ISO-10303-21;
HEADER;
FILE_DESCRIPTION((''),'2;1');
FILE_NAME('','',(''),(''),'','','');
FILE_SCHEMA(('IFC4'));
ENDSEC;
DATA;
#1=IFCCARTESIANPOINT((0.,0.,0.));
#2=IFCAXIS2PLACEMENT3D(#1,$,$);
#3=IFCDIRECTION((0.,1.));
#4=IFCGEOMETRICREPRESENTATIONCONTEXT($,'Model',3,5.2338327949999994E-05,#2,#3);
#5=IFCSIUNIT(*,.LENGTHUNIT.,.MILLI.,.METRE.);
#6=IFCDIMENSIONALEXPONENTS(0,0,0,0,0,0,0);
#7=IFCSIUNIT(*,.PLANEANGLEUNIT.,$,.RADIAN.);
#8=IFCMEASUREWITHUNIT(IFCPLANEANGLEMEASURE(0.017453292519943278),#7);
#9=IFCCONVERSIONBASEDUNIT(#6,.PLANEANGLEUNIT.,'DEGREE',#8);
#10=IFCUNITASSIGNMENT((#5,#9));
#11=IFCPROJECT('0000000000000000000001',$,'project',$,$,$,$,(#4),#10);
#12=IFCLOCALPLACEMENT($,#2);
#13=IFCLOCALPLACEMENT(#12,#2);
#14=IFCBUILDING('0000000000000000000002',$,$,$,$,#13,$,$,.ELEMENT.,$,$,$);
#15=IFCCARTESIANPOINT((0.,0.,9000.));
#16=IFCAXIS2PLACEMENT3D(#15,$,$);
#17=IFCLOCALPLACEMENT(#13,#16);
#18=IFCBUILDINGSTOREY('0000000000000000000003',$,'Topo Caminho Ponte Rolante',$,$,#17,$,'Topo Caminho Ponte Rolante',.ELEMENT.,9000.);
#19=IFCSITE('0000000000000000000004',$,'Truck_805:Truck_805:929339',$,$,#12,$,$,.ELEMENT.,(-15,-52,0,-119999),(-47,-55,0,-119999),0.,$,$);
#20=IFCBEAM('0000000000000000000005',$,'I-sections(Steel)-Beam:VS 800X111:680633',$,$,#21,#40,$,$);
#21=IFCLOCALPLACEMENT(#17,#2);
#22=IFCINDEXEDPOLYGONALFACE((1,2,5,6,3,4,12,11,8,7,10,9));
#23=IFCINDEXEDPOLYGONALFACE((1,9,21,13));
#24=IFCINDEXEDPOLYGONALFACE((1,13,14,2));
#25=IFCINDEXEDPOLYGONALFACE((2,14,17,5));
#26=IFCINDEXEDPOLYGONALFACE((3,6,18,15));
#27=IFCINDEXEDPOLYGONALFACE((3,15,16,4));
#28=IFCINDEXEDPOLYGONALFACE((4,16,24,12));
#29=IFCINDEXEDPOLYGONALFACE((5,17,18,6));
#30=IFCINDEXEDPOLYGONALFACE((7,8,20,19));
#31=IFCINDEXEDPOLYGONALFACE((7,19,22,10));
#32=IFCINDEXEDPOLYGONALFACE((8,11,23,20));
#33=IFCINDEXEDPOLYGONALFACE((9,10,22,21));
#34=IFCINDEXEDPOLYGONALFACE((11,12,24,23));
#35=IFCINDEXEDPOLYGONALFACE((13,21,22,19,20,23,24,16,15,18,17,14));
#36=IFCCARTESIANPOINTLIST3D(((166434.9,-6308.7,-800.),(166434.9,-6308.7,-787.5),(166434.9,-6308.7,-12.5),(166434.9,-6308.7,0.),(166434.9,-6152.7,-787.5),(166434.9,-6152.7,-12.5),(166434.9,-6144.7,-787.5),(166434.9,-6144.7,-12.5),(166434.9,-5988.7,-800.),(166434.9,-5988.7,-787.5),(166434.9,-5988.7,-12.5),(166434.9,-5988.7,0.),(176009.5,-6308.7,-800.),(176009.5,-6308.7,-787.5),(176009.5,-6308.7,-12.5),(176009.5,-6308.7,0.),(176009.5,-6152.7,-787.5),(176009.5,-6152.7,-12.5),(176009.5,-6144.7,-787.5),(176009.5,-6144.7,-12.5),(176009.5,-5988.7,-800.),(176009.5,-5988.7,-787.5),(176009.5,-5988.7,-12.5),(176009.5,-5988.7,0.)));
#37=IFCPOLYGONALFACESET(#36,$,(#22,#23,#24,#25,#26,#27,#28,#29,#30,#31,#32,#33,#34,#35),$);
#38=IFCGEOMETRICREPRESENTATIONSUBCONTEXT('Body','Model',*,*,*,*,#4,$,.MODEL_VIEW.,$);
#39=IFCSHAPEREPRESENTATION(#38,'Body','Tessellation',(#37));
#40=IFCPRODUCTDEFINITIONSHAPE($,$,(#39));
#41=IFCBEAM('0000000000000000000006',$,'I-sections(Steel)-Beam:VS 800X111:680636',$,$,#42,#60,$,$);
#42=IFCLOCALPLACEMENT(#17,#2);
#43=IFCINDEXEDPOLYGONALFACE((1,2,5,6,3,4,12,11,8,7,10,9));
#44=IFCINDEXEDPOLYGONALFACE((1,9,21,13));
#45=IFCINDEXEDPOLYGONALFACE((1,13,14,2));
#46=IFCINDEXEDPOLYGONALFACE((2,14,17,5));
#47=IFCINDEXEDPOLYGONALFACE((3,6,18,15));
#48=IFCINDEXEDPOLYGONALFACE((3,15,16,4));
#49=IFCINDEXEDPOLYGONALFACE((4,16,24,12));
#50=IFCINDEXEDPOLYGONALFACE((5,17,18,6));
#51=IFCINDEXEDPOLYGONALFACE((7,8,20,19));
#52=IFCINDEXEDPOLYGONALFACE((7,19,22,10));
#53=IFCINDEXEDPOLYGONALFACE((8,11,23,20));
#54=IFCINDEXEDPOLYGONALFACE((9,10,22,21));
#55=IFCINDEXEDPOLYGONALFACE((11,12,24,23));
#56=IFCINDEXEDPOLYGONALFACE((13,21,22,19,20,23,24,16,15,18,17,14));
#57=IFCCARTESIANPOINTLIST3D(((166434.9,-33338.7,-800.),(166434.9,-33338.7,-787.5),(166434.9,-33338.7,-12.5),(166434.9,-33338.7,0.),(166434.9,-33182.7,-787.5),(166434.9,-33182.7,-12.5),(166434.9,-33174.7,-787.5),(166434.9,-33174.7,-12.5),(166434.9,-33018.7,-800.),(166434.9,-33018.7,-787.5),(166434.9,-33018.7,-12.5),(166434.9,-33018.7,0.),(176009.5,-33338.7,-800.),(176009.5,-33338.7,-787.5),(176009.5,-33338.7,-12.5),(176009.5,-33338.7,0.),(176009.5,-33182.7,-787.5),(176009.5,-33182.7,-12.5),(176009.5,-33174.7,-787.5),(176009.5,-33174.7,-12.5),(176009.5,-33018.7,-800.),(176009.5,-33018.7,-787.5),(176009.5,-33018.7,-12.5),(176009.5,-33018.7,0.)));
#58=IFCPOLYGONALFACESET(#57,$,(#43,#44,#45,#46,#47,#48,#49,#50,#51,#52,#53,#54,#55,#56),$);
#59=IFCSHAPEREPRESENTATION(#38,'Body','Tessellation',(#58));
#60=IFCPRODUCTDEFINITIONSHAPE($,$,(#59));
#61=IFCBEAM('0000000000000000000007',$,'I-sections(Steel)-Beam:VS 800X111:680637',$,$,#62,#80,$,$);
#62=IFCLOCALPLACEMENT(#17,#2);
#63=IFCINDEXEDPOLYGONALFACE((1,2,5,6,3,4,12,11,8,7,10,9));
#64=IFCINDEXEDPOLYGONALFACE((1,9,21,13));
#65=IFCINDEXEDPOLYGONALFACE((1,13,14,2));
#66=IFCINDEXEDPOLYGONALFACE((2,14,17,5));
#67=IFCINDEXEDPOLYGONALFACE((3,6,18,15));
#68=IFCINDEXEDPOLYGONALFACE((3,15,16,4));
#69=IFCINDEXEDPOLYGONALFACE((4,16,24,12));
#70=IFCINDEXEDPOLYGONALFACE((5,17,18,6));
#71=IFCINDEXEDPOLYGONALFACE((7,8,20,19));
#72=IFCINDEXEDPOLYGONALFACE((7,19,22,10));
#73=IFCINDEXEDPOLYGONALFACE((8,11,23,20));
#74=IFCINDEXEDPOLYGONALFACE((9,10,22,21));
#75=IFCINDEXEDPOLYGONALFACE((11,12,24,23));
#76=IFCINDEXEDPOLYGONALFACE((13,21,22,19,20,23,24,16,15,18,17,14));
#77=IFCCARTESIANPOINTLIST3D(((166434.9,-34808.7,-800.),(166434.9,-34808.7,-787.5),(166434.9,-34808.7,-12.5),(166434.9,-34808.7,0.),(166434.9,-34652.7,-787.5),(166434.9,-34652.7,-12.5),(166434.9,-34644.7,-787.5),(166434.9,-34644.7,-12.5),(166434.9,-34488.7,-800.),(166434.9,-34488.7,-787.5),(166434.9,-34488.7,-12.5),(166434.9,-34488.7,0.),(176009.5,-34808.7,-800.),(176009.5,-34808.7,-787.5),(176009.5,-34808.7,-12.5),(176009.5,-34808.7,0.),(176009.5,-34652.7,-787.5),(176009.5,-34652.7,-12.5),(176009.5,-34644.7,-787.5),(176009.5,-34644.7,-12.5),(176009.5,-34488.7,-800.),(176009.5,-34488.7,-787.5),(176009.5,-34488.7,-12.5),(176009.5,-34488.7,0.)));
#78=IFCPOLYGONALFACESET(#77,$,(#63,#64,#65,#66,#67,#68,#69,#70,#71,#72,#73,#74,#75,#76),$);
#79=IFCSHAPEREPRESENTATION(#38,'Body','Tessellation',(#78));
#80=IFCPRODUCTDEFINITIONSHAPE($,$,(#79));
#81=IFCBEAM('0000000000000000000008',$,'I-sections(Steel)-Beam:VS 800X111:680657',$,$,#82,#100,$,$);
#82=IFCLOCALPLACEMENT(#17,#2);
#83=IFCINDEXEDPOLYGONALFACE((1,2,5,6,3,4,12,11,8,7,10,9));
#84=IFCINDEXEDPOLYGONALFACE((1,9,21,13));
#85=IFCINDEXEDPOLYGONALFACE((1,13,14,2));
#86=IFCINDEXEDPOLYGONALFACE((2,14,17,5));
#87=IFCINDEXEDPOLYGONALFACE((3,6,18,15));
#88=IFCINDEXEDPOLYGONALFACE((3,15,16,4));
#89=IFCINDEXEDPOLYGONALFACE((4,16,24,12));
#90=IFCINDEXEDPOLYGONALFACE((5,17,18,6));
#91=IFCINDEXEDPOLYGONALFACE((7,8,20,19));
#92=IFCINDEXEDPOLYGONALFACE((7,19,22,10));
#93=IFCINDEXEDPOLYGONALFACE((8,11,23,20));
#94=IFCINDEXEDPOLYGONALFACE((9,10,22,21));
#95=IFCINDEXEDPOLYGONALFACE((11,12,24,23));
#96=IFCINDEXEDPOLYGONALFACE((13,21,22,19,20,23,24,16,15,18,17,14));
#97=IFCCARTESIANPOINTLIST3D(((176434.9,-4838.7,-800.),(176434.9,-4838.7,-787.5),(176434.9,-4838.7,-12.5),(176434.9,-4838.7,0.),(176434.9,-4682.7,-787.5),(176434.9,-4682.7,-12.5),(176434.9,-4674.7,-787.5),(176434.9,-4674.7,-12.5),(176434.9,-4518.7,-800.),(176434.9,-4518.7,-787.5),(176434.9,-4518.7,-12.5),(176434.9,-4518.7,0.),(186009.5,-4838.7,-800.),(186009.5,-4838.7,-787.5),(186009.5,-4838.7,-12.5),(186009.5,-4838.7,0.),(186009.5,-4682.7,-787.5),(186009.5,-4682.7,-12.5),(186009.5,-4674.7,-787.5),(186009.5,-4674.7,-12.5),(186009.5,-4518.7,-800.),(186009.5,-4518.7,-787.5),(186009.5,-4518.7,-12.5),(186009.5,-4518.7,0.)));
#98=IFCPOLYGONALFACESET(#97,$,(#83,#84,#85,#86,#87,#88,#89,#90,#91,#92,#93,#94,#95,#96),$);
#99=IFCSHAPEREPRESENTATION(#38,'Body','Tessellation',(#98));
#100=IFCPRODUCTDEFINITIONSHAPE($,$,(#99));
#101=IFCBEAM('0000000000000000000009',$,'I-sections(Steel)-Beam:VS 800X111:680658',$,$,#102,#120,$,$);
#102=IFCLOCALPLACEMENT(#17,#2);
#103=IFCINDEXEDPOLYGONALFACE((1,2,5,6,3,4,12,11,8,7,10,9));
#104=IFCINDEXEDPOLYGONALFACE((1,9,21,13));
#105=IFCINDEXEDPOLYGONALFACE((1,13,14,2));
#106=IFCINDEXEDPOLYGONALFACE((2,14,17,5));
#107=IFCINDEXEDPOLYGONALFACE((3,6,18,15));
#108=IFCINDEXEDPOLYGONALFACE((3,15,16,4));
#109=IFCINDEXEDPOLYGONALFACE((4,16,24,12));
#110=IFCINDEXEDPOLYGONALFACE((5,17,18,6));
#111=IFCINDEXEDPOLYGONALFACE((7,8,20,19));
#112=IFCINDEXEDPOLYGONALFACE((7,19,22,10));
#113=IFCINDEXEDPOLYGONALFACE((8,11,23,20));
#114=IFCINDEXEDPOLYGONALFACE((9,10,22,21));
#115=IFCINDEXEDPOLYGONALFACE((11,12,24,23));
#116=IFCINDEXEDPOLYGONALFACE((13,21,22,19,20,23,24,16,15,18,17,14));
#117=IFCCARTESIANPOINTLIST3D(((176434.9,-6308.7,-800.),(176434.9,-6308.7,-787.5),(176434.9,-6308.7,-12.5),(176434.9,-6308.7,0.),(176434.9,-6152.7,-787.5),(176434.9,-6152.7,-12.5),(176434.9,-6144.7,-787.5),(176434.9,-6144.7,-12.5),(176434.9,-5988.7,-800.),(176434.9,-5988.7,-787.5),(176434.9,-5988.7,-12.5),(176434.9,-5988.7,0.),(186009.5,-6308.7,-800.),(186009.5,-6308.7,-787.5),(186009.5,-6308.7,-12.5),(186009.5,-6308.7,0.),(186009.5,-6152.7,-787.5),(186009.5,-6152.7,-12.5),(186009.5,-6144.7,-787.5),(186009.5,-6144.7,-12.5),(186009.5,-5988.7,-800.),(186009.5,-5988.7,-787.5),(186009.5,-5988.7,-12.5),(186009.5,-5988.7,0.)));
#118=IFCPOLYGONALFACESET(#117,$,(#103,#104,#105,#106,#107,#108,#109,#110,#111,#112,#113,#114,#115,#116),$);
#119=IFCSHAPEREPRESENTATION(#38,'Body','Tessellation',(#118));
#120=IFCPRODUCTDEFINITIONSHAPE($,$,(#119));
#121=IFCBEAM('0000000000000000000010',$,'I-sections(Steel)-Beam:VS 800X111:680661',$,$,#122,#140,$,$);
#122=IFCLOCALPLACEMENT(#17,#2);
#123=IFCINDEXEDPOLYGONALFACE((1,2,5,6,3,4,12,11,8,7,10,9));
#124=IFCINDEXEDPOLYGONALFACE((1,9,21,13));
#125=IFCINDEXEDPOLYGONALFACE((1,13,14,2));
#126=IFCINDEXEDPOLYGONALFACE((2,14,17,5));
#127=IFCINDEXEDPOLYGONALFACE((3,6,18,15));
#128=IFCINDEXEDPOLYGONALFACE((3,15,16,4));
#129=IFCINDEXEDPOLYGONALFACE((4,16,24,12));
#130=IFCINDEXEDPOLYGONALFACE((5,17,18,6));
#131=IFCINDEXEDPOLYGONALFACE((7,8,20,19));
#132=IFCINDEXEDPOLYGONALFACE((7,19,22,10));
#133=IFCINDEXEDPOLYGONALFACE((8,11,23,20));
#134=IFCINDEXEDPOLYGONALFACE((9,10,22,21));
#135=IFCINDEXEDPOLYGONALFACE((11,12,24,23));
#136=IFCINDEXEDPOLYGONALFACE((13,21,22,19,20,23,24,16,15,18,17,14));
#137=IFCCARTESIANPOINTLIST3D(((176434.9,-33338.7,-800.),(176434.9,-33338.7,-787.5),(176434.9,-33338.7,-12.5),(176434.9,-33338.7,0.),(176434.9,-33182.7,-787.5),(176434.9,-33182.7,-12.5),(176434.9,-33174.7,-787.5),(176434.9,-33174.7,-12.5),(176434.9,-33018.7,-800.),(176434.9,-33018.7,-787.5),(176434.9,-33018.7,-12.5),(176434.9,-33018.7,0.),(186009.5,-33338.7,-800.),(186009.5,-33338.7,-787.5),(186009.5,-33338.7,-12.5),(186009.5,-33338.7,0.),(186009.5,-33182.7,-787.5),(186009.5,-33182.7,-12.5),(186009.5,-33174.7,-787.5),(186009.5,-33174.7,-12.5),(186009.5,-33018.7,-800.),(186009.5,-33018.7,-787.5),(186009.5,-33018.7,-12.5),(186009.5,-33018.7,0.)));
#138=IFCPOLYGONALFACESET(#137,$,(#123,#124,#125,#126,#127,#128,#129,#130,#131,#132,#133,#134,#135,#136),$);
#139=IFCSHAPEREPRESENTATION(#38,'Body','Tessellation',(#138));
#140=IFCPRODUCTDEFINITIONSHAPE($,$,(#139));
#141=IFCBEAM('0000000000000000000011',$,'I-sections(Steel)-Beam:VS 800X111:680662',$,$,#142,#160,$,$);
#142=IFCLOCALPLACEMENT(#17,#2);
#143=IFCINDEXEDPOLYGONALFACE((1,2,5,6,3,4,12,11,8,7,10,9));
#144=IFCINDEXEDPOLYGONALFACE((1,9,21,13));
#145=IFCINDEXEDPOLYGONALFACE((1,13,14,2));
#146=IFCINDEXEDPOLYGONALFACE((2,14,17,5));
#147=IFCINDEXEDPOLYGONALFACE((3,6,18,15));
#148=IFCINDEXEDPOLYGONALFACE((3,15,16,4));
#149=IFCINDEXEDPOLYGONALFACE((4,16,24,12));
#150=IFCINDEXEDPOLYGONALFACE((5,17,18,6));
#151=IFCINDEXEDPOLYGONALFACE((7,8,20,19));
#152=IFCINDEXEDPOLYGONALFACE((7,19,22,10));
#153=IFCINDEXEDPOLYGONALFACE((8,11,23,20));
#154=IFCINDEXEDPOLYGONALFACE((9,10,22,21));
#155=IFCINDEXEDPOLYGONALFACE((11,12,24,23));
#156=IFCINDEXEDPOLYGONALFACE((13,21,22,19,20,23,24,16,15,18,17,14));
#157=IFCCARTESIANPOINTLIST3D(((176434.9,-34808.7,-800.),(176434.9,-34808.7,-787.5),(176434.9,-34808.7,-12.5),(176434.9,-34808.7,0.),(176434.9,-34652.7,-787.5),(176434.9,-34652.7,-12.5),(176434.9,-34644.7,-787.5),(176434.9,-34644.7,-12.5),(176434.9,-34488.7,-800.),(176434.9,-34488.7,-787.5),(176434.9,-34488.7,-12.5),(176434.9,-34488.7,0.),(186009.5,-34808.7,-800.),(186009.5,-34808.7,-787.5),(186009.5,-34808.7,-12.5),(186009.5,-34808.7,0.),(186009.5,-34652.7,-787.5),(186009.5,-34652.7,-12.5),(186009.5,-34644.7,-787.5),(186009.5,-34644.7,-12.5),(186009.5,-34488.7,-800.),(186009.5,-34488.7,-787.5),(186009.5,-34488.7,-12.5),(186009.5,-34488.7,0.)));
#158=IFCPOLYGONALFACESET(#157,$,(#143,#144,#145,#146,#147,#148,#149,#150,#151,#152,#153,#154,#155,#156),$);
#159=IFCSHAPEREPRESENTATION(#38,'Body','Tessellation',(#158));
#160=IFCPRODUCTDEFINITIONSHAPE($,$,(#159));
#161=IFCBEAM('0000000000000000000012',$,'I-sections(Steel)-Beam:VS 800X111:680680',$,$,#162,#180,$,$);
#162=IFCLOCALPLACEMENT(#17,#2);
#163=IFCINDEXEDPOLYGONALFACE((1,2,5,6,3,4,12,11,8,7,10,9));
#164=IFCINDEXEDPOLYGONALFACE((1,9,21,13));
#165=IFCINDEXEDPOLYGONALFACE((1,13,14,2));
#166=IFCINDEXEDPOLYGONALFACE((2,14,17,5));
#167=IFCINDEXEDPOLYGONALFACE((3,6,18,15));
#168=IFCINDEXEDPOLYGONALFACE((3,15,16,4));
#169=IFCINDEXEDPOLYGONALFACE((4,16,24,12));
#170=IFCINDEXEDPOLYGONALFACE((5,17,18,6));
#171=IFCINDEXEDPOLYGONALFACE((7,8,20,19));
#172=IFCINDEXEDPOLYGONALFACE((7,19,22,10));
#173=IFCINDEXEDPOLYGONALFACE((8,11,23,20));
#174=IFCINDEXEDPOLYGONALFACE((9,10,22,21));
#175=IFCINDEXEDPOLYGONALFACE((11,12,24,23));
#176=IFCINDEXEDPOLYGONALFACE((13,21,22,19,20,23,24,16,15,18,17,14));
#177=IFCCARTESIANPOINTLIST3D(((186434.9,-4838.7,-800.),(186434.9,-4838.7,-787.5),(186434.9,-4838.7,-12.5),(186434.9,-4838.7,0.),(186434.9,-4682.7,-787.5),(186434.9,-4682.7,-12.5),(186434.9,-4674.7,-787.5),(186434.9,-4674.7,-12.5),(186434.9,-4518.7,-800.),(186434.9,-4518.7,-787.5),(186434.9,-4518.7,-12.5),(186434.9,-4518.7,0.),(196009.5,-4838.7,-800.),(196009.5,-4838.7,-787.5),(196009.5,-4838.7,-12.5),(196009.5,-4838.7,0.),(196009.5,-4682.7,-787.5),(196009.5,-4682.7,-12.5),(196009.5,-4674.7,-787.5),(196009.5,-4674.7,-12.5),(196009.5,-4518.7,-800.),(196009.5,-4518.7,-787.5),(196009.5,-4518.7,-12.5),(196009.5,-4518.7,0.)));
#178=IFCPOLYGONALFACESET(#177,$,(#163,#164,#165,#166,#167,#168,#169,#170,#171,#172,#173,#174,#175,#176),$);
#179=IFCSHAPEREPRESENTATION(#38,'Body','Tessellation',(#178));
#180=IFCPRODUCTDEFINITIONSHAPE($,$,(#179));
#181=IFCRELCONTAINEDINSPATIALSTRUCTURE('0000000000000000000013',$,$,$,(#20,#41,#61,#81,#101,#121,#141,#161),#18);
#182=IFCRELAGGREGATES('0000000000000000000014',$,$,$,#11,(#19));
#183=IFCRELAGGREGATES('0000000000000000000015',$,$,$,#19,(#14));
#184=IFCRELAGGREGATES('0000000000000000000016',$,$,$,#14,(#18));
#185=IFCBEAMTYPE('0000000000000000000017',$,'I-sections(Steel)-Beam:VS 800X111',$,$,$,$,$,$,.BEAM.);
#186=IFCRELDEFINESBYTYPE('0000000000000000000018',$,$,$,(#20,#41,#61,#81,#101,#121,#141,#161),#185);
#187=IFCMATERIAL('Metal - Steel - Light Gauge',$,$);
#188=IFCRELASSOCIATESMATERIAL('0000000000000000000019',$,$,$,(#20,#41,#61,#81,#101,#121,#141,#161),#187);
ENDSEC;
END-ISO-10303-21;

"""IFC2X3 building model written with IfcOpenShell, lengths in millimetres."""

from ifc_helpers import new_model, entity, si_unit, converted_unit, direction, frame, frame_2d, origin, place, context, subcontext, project, spatial, polyline, i_section, outline, extrude, material, type_object, element, save


model = new_model("IFC2X3")

# Units and contexts
model_context = context("Model", 3, precision=5.2338327949999994e-05, world=origin(), true_north=direction((0.0, 1.0)))
body_context = subcontext(model_context, "Body", "Model", "MODEL_VIEW")
ifc_project = project(units=[si_unit("LENGTHUNIT", "METRE", prefix="MILLI"), converted_unit("PLANEANGLEUNIT", "DEGREE", entity("IfcPlaneAngleMeasure", 0.017453292519943278), si_unit("PLANEANGLEUNIT", "RADIAN"), dimensions=[0, 0, 0, 0, 0, 0, 0])], contexts=[model_context])

# Site, building, storey
site_placement = place(None, origin())
site = spatial("IfcSite", under=ifc_project, at=site_placement, Name="Truck_805:Truck_805:929339", CompositionType="ELEMENT", RefLatitude=(-15, -52, 0, -119999), RefLongitude=(-47, -55, 0, -119999), RefElevation=0.0)
building_placement = place(site_placement, origin())
building = spatial("IfcBuilding", under=site, at=building_placement, CompositionType="ELEMENT")
storey_placement = place(building_placement, frame((0.0, 0.0, 9000.0)))
storey = spatial("IfcBuildingStorey", under=building, at=storey_placement, Name="Topo Caminho Ponte Rolante", LongName="Topo Caminho Ponte Rolante", CompositionType="ELEMENT", Elevation=9000.0)

# Beams
ifc_material = material(Name="Metal - Steel - Light Gauge")
beam_type_1 = type_object("IfcBeamType", Name="I-sections(Steel)-Beam:VS 800X111", PredefinedType="BEAM")
beam_1_placement = place(storey_placement, frame((166222.2, -6148.7, 0.0)))
element("IfcBeam", 1, at=beam_1_placement, inside=storey, type_object=beam_type_1, material=ifc_material, Name="I-sections(Steel)-Beam:VS 800X111:680633", context=body_context, shape_type="SweptSolid", body=[
    extrude(outline(polyline([(387.5, -160.0), (400.0, -160.0), (400.0, 160.0), (387.5, 160.0), (387.5, 4.0), (-387.5, 4.0), (-387.5, 160.0), (-400.0, 160.0), (-400.0, -160.0), (-387.5, -160.0), (-387.5, -4.0), (387.5, -4.0), (387.5, -160.0)])), frame((212.7, 0.0, -400.0), z_axis=(1.0, 0.0, 0.0), x_axis=(0.0, 0.0, -1.0)), (0.0, 0.0, 1.0), 9574.6),
])
beam_2_placement = place(storey_placement, frame((166222.2, -33178.7, 0.0)))
element("IfcBeam", 2, at=beam_2_placement, inside=storey, type_object=beam_type_1, material=ifc_material, Name="I-sections(Steel)-Beam:VS 800X111:680636", context=body_context, shape_type="SweptSolid", body=[
    extrude(i_section(OverallWidth=320.0, OverallDepth=800.0, WebThickness=8.0, FlangeThickness=12.5, at=frame_2d((0.0, 0.0), x_axis=(0.0, 1.0))), frame((212.7, 0.0, -400.0), z_axis=(1.0, 0.0, 0.0), x_axis=(0.0, 0.0, -1.0)), (0.0, 0.0, 1.0), 9574.6),
])
beam_3_placement = place(storey_placement, frame((166222.2, -34648.7, 0.0)))
element("IfcBeam", 3, at=beam_3_placement, inside=storey, type_object=beam_type_1, material=ifc_material, Name="I-sections(Steel)-Beam:VS 800X111:680637", context=body_context, shape_type="SweptSolid", body=[
    extrude(outline(polyline([(387.5, -160.0), (400.0, -160.0), (400.0, 160.0), (387.5, 160.0), (387.5, 4.0), (-387.5, 4.0), (-387.5, 160.0), (-400.0, 160.0), (-400.0, -160.0), (-387.5, -160.0), (-387.5, -4.0), (387.5, -4.0), (387.5, -160.0)])), frame((212.7, 0.0, -400.0), z_axis=(1.0, 0.0, 0.0), x_axis=(0.0, 0.0, -1.0)), (0.0, 0.0, 1.0), 9574.6),
])
beam_4_placement = place(storey_placement, frame((176222.2, -4678.7, 0.0)))
element("IfcBeam", 4, at=beam_4_placement, inside=storey, type_object=beam_type_1, material=ifc_material, Name="I-sections(Steel)-Beam:VS 800X111:680657", context=body_context, shape_type="SweptSolid", body=[
    extrude(i_section(OverallWidth=320.0, OverallDepth=800.0, WebThickness=8.0, FlangeThickness=12.5, at=frame_2d((0.0, 0.0), x_axis=(0.0, 1.0))), frame((212.7, 0.0, -400.0), z_axis=(1.0, 0.0, 0.0), x_axis=(0.0, 0.0, -1.0)), (0.0, 0.0, 1.0), 9574.6),
])
beam_5_placement = place(storey_placement, frame((176222.2, -6148.7, 0.0)))
element("IfcBeam", 5, at=beam_5_placement, inside=storey, type_object=beam_type_1, material=ifc_material, Name="I-sections(Steel)-Beam:VS 800X111:680658", context=body_context, shape_type="SweptSolid", body=[
    extrude(outline(polyline([(387.5, -160.0), (400.0, -160.0), (400.0, 160.0), (387.5, 160.0), (387.5, 4.0), (-387.5, 4.0), (-387.5, 160.0), (-400.0, 160.0), (-400.0, -160.0), (-387.5, -160.0), (-387.5, -4.0), (387.5, -4.0), (387.5, -160.0)])), frame((212.7, 0.0, -400.0), z_axis=(1.0, 0.0, 0.0), x_axis=(0.0, 0.0, -1.0)), (0.0, 0.0, 1.0), 9574.6),
])
beam_6_placement = place(storey_placement, frame((176222.2, -33178.7, 0.0)))
element("IfcBeam", 6, at=beam_6_placement, inside=storey, type_object=beam_type_1, material=ifc_material, Name="I-sections(Steel)-Beam:VS 800X111:680661", context=body_context, shape_type="SweptSolid", body=[
    extrude(i_section(OverallWidth=320.0, OverallDepth=800.0, WebThickness=8.0, FlangeThickness=12.5, at=frame_2d((0.0, 0.0), x_axis=(0.0, 1.0))), frame((212.7, 0.0, -400.0), z_axis=(1.0, 0.0, 0.0), x_axis=(0.0, 0.0, -1.0)), (0.0, 0.0, 1.0), 9574.6),
])
beam_7_placement = place(storey_placement, frame((176222.2, -34648.7, 0.0)))
element("IfcBeam", 7, at=beam_7_placement, inside=storey, type_object=beam_type_1, material=ifc_material, Name="I-sections(Steel)-Beam:VS 800X111:680662", context=body_context, shape_type="SweptSolid", body=[
    extrude(outline(polyline([(387.5, -160.0), (400.0, -160.0), (400.0, 160.0), (387.5, 160.0), (387.5, 4.0), (-387.5, 4.0), (-387.5, 160.0), (-400.0, 160.0), (-400.0, -160.0), (-387.5, -160.0), (-387.5, -4.0), (387.5, -4.0), (387.5, -160.0)])), frame((212.7, 0.0, -400.0), z_axis=(1.0, 0.0, 0.0), x_axis=(0.0, 0.0, -1.0)), (0.0, 0.0, 1.0), 9574.6),
])
beam_8_placement = place(storey_placement, frame((186222.2, -4678.7, 0.0)))
element("IfcBeam", 8, at=beam_8_placement, inside=storey, type_object=beam_type_1, material=ifc_material, Name="I-sections(Steel)-Beam:VS 800X111:680680", context=body_context, shape_type="SweptSolid", body=[
    extrude(i_section(OverallWidth=320.0, OverallDepth=800.0, WebThickness=8.0, FlangeThickness=12.5, at=frame_2d((0.0, 0.0), x_axis=(0.0, 1.0))), frame((212.7, 0.0, -400.0), z_axis=(1.0, 0.0, 0.0), x_axis=(0.0, 0.0, -1.0)), (0.0, 0.0, 1.0), 9574.6),
])

save(model, "model.ifc")
